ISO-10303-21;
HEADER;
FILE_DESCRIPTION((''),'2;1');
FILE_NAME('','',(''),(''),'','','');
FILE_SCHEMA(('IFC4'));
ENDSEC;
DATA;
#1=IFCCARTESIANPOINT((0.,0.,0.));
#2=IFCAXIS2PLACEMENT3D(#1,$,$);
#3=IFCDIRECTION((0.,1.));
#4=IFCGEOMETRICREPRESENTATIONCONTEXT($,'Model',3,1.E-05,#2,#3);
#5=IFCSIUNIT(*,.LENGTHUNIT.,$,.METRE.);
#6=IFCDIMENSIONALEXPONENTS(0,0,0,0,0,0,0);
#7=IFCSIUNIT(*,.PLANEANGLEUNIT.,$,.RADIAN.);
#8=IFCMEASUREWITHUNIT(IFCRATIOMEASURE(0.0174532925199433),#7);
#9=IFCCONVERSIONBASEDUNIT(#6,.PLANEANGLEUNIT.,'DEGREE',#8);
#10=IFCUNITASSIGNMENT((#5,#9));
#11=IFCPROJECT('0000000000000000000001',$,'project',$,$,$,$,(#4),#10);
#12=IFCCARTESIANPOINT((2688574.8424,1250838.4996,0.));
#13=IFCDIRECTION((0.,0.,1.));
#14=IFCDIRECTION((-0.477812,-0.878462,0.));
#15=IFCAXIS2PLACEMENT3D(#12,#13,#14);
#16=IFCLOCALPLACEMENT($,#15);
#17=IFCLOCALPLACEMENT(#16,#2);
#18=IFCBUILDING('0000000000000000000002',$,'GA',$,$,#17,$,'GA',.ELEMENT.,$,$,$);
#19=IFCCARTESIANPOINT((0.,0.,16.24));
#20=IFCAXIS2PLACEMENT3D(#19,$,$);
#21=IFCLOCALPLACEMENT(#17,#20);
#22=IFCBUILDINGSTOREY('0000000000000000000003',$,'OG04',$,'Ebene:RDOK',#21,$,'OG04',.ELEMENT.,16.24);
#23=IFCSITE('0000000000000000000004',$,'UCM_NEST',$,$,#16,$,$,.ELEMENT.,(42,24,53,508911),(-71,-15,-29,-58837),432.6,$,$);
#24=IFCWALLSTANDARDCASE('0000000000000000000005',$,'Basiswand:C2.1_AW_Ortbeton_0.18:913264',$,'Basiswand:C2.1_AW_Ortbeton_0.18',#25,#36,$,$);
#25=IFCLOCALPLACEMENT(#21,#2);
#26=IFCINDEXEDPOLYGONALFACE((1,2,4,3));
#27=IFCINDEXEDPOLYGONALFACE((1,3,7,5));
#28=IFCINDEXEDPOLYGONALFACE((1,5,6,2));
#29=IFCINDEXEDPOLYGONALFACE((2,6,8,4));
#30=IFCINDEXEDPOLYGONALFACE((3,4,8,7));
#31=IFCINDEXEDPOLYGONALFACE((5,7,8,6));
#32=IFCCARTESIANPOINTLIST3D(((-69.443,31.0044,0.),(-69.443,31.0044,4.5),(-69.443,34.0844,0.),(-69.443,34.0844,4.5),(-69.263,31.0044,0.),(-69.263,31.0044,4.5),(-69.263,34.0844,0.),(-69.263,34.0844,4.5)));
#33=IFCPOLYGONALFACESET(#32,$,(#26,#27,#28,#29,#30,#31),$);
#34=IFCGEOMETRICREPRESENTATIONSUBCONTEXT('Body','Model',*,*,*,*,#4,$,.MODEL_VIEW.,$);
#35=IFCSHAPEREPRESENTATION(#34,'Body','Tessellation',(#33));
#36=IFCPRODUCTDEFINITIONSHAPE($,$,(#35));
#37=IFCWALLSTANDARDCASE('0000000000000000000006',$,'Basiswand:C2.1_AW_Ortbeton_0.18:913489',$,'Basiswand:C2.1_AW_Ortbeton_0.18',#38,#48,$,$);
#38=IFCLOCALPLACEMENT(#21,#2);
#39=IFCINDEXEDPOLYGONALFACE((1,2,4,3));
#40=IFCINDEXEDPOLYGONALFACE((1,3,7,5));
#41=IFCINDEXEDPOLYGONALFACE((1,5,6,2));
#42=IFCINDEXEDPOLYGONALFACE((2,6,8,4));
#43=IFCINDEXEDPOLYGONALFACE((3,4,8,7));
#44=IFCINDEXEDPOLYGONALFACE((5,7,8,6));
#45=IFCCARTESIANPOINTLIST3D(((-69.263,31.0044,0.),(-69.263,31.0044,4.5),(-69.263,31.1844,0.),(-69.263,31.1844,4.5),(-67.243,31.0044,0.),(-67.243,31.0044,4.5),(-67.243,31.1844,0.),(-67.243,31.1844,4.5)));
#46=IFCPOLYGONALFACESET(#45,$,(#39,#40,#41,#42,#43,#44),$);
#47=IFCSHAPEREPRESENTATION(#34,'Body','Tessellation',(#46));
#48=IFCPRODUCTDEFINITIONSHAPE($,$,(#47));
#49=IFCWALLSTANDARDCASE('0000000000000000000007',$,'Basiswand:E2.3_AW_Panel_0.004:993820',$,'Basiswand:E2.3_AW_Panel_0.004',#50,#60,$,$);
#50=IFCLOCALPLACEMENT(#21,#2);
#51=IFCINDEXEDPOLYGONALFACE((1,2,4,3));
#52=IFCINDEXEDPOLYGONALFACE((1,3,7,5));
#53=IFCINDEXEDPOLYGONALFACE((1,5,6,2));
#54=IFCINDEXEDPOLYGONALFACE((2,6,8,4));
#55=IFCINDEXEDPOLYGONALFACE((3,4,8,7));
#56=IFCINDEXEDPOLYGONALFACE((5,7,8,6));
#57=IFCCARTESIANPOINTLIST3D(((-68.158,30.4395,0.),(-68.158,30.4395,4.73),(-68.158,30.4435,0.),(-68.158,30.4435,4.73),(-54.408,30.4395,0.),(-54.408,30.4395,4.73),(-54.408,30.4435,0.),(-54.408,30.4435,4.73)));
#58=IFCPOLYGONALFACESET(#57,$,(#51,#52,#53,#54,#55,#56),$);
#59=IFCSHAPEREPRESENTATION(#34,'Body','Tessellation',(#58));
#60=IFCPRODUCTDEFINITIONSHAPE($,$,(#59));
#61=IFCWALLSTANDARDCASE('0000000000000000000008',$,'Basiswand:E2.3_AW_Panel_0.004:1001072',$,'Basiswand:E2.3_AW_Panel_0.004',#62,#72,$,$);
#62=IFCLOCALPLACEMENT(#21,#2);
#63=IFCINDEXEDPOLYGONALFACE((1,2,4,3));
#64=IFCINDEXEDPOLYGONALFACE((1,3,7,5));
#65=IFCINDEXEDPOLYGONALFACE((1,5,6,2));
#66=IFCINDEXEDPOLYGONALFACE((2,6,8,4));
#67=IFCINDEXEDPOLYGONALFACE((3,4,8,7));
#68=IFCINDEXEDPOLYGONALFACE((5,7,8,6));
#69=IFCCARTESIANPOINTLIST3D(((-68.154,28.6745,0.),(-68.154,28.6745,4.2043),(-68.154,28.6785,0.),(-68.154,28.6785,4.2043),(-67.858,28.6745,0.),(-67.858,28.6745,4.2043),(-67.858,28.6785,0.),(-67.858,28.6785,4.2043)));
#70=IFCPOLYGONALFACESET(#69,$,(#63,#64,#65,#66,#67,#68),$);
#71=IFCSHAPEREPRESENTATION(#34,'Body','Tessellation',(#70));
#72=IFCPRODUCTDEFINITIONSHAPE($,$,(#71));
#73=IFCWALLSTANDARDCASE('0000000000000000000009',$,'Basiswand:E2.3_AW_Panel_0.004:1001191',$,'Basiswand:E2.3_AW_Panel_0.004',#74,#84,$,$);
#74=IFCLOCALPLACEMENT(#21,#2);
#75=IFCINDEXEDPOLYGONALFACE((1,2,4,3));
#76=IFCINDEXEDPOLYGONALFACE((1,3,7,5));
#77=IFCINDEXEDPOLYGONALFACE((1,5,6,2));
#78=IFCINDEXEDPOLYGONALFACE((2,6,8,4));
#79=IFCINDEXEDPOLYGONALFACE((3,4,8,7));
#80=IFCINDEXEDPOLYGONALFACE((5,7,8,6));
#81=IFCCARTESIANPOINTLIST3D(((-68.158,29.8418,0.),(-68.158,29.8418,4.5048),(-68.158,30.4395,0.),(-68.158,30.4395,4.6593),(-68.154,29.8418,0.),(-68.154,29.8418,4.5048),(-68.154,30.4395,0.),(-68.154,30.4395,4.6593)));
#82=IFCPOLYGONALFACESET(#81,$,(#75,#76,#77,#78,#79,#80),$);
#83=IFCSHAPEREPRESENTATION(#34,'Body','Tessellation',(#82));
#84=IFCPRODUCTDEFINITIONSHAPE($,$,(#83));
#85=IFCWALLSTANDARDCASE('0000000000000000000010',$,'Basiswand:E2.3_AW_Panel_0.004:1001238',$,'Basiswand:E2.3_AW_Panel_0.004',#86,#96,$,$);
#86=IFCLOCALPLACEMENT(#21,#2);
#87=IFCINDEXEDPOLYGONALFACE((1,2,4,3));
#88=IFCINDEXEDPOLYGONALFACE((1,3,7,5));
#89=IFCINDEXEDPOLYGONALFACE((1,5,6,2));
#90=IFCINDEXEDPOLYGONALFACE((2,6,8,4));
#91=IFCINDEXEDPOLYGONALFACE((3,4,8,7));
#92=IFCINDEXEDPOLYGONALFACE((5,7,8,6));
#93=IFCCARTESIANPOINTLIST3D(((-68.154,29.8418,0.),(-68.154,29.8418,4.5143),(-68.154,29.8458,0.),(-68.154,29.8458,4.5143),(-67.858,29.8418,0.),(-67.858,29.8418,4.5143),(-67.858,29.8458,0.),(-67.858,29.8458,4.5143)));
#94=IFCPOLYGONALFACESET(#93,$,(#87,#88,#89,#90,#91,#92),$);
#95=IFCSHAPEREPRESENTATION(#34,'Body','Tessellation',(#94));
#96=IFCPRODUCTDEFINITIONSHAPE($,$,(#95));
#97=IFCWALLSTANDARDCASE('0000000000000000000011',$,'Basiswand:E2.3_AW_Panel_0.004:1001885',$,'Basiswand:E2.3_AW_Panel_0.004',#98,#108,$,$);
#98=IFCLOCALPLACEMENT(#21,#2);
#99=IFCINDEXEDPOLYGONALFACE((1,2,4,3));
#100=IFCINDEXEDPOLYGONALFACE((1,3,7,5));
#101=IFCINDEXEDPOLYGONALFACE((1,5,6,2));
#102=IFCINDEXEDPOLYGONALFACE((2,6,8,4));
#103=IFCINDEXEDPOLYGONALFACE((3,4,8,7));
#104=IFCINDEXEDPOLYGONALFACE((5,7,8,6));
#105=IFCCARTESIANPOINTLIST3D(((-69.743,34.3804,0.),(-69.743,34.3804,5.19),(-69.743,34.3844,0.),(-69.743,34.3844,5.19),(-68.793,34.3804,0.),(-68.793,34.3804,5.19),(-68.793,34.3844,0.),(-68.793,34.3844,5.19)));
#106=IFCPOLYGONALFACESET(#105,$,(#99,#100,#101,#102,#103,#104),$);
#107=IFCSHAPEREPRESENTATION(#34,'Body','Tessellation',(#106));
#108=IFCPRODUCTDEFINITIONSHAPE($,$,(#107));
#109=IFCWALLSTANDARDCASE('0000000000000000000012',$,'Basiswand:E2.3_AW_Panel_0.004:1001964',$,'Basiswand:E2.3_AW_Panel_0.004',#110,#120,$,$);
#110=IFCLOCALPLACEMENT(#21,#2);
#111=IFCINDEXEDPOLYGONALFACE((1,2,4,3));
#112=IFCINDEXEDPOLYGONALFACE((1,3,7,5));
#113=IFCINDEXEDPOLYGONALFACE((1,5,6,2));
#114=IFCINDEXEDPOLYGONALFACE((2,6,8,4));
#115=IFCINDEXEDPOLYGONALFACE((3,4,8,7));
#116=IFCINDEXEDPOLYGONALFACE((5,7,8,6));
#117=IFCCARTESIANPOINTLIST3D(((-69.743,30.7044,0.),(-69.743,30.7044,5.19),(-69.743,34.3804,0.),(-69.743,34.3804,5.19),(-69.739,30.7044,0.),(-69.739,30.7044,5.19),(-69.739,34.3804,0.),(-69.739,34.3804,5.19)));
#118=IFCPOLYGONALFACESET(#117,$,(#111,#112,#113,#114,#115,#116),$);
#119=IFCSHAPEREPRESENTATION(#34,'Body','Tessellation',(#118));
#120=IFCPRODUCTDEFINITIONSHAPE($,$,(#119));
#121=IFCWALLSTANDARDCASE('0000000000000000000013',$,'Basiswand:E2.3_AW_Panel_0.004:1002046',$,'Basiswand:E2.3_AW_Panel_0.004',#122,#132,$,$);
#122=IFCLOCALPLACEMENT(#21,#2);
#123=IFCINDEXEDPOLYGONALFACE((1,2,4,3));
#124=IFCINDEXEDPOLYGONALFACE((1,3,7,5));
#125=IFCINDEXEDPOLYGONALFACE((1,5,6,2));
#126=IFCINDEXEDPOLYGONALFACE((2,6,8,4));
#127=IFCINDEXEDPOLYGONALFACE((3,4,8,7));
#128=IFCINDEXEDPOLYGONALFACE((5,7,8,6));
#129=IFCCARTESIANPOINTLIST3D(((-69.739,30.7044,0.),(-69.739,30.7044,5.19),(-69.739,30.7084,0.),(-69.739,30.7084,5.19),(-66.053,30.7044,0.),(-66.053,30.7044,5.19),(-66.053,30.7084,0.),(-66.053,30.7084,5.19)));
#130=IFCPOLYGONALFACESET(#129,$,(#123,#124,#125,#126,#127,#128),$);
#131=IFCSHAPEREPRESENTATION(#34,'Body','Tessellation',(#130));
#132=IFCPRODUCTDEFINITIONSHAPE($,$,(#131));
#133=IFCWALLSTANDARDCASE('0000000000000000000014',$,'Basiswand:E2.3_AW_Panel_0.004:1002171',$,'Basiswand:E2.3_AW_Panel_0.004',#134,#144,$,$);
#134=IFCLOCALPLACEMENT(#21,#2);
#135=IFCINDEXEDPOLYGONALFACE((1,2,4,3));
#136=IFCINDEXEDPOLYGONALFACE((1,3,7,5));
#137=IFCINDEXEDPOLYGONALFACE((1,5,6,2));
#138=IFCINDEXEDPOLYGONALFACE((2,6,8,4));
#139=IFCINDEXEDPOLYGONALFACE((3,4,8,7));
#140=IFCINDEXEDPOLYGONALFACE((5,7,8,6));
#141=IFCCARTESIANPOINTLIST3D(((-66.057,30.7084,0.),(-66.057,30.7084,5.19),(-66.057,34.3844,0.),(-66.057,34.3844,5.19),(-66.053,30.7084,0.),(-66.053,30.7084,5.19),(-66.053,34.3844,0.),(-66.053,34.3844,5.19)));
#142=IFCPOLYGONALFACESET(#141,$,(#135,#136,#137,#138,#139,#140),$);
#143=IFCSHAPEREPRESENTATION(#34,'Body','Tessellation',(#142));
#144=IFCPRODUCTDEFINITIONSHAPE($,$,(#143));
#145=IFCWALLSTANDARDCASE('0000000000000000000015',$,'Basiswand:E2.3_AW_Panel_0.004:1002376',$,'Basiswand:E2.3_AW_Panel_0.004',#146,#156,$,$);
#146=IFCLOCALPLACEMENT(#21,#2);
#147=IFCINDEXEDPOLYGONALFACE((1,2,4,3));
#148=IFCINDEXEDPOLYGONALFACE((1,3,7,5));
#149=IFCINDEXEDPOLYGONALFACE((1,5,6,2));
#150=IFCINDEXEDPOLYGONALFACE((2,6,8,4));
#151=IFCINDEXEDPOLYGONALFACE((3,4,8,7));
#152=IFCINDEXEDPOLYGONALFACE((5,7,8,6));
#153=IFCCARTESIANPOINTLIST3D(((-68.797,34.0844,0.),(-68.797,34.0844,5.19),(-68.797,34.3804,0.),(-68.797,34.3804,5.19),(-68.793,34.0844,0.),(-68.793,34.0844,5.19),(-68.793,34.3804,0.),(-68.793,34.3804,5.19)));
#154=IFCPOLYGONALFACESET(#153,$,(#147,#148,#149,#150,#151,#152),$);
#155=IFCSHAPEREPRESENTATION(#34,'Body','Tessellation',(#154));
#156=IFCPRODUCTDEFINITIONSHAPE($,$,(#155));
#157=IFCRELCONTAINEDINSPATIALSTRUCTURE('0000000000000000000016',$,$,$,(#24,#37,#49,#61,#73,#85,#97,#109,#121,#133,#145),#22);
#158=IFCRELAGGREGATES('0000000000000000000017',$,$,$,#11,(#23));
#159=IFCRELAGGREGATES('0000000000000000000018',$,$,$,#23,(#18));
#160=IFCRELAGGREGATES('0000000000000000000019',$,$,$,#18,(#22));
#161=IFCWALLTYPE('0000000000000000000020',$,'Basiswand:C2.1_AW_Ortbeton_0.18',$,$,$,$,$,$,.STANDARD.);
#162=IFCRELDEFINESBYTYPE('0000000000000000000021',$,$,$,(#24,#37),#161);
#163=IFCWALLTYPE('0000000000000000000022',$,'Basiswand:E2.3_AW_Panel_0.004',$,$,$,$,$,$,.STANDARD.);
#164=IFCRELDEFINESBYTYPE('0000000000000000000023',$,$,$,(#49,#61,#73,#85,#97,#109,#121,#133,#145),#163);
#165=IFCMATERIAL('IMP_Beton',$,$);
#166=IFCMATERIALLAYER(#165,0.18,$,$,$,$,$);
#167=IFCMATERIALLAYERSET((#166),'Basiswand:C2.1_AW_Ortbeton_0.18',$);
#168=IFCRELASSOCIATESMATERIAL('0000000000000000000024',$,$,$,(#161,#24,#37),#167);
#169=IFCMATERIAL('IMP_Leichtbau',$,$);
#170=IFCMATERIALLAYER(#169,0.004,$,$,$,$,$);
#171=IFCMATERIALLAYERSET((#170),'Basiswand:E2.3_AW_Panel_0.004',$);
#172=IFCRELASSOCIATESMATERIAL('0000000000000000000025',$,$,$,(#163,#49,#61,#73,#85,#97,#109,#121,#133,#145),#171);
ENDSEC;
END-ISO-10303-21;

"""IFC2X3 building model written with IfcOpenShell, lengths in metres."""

from ifc_helpers import new_model, entity, si_unit, converted_unit, direction, frame, frame_2d, origin, place, context, subcontext, project, spatial, rectangle, extrude, clip, halfspace, material, layer, layer_set, layer_usage, type_object, element, save


model = new_model("IFC2X3")

# Units and contexts
model_context = context("Model", 3, precision=1e-05, world=origin(), true_north=direction((0.0, 1.0)))
body_context = subcontext(model_context, "Body", "Model", "MODEL_VIEW")
ifc_project = project(units=[si_unit("LENGTHUNIT", "METRE"), converted_unit("PLANEANGLEUNIT", "DEGREE", entity("IfcRatioMeasure", 0.0174532925199433), si_unit("PLANEANGLEUNIT", "RADIAN"), dimensions=[0, 0, 0, 0, 0, 0, 0])], contexts=[model_context])

# Site, building, storey
site_placement = place(None, frame((2688574.8424, 1250838.4996, 0.0), z_axis=(0.0, 0.0, 1.0), x_axis=(-0.477812, -0.878462, 0.0)))
site = spatial("IfcSite", under=ifc_project, at=site_placement, Name="UCM_NEST", CompositionType="ELEMENT", RefLatitude=(42, 24, 53, 508911), RefLongitude=(-71, -15, -29, -58837), RefElevation=432.6)
building_placement = place(site_placement, origin())
building = spatial("IfcBuilding", under=site, at=building_placement, Name="GA", LongName="GA", CompositionType="ELEMENT")
storey_placement = place(building_placement, frame((0.0, 0.0, 16.24)))
storey = spatial("IfcBuildingStorey", under=building, at=storey_placement, Name="OG04", ObjectType="Ebene:RDOK", LongName="OG04", CompositionType="ELEMENT", Elevation=16.24)

# Shared definitions
ifc_material_1 = material(Name="IMP_Beton")

# Walls
ifc_layer_1 = layer(ifc_material_1, 0.18)
ifc_layer_set_1 = layer_set([ifc_layer_1], Name="Basiswand:C2.1_AW_Ortbeton_0.18")
ifc_layer_usage_1 = layer_usage(ifc_layer_set_1, "AXIS2", "NEGATIVE", 0.09)
wall_type_1 = type_object("IfcWallType", Name="Basiswand:C2.1_AW_Ortbeton_0.18", PredefinedType="STANDARD", material=ifc_layer_set_1)
wall_1_placement = place(storey_placement, frame((-69.353, 31.0044, 0.0), z_axis=(0.0, 0.0, 1.0), x_axis=(0.0, 1.0, 0.0)))
element("IfcWallStandardCase", 1, at=wall_1_placement, inside=storey, type_object=wall_type_1, material=ifc_layer_usage_1, Name="Basiswand:C2.1_AW_Ortbeton_0.18:913264", ObjectType="Basiswand:C2.1_AW_Ortbeton_0.18", context=body_context, shape_type="SweptSolid", body=[
    extrude(rectangle(XDim=3.08, YDim=0.18, at=frame_2d((1.54, 0.0), x_axis=(-1.0, 0.0))), origin(), (0.0, 0.0, 1.0), 4.5),
])
ifc_layer_usage_2 = layer_usage(ifc_layer_set_1, "AXIS2", "NEGATIVE", 0.09)
wall_2_placement = place(storey_placement, frame((-67.243, 31.0944, 0.0), z_axis=(0.0, 0.0, 1.0), x_axis=(-1.0, 0.0, 0.0)))
element("IfcWallStandardCase", 2, at=wall_2_placement, inside=storey, type_object=wall_type_1, material=ifc_layer_usage_2, Name="Basiswand:C2.1_AW_Ortbeton_0.18:913489", ObjectType="Basiswand:C2.1_AW_Ortbeton_0.18", context=body_context, shape_type="SweptSolid", body=[
    extrude(rectangle(XDim=2.02, YDim=0.18, at=frame_2d((1.01, 0.0), x_axis=(-1.0, 0.0))), origin(), (0.0, 0.0, 1.0), 4.5),
])
ifc_material_2 = material(Name="IMP_Leichtbau")
ifc_layer_2 = layer(ifc_material_2, 0.004)
ifc_layer_set_2 = layer_set([ifc_layer_2], Name="Basiswand:E2.3_AW_Panel_0.004")
ifc_layer_usage_3 = layer_usage(ifc_layer_set_2, "AXIS2", "NEGATIVE", 0.002)
wall_type_2 = type_object("IfcWallType", Name="Basiswand:E2.3_AW_Panel_0.004", PredefinedType="STANDARD", material=ifc_layer_set_2)
wall_3_placement = place(storey_placement, frame((-68.158, 30.4415, 0.0)))
element("IfcWallStandardCase", 3, at=wall_3_placement, inside=storey, type_object=wall_type_2, material=ifc_layer_usage_3, Name="Basiswand:E2.3_AW_Panel_0.004:993820", ObjectType="Basiswand:E2.3_AW_Panel_0.004", context=body_context, shape_type="SweptSolid", body=[
    extrude(rectangle(XDim=13.75, YDim=0.004, at=frame_2d((6.875, 0.0), x_axis=(-1.0, 0.0))), origin(), (0.0, 0.0, 1.0), 4.73),
])
ifc_layer_usage_4 = layer_usage(ifc_layer_set_2, "AXIS2", "NEGATIVE", 0.002)
wall_4_placement = place(storey_placement, frame((-68.154, 28.6765, 0.0)))
element("IfcWallStandardCase", 4, at=wall_4_placement, inside=storey, type_object=wall_type_2, material=ifc_layer_usage_4, Name="Basiswand:E2.3_AW_Panel_0.004:1001072", ObjectType="Basiswand:E2.3_AW_Panel_0.004", context=body_context, shape_type="SweptSolid", body=[
    extrude(rectangle(XDim=0.296, YDim=0.004, at=frame_2d((0.148, 0.0), x_axis=(-1.0, 0.0))), origin(), (0.0, 0.0, 1.0), 4.2043),
])
ifc_layer_usage_5 = layer_usage(ifc_layer_set_2, "AXIS2", "NEGATIVE", 0.002)
wall_5_placement = place(storey_placement, frame((-68.156, 30.4395, 0.0), z_axis=(0.0, 0.0, 1.0), x_axis=(0.0, -1.0, 0.0)))
element("IfcWallStandardCase", 5, at=wall_5_placement, inside=storey, type_object=wall_type_2, material=ifc_layer_usage_5, Name="Basiswand:E2.3_AW_Panel_0.004:1001191", ObjectType="Basiswand:E2.3_AW_Panel_0.004", context=body_context, shape_type="Clipping", body=[
    clip(extrude(rectangle(XDim=0.5977, YDim=0.004, at=frame_2d((0.2988, 0.0), x_axis=(-1.0, 0.0))), origin(), (0.0, 0.0, 1.0), 4.6593), halfspace(frame((0.0, -0.002, 4.6593), z_axis=(0.250322, 0.0, 0.968163), x_axis=(0.0, 1.0, 0.0)), False)),
])
ifc_layer_usage_6 = layer_usage(ifc_layer_set_2, "AXIS2", "NEGATIVE", 0.002)
wall_6_placement = place(storey_placement, frame((-68.154, 29.8438, 0.0)))
element("IfcWallStandardCase", 6, at=wall_6_placement, inside=storey, type_object=wall_type_2, material=ifc_layer_usage_6, Name="Basiswand:E2.3_AW_Panel_0.004:1001238", ObjectType="Basiswand:E2.3_AW_Panel_0.004", context=body_context, shape_type="SweptSolid", body=[
    extrude(rectangle(XDim=0.296, YDim=0.004, at=frame_2d((0.148, 0.0), x_axis=(-1.0, 0.0))), origin(), (0.0, 0.0, 1.0), 4.5143),
])
ifc_layer_usage_7 = layer_usage(ifc_layer_set_2, "AXIS2", "NEGATIVE", 0.002)
wall_7_placement = place(storey_placement, frame((-68.793, 34.3824, 0.0), z_axis=(0.0, 0.0, 1.0), x_axis=(-1.0, 0.0, 0.0)))
element("IfcWallStandardCase", 7, at=wall_7_placement, inside=storey, type_object=wall_type_2, material=ifc_layer_usage_7, Name="Basiswand:E2.3_AW_Panel_0.004:1001885", ObjectType="Basiswand:E2.3_AW_Panel_0.004", context=body_context, shape_type="SweptSolid", body=[
    extrude(rectangle(XDim=0.95, YDim=0.004, at=frame_2d((0.475, 0.0), x_axis=(-1.0, 0.0))), origin(), (0.0, 0.0, 1.0), 5.19),
])
ifc_layer_usage_8 = layer_usage(ifc_layer_set_2, "AXIS2", "NEGATIVE", 0.002)
wall_8_placement = place(storey_placement, frame((-69.741, 34.3804, 0.0), z_axis=(0.0, 0.0, 1.0), x_axis=(0.0, -1.0, 0.0)))
element("IfcWallStandardCase", 8, at=wall_8_placement, inside=storey, type_object=wall_type_2, material=ifc_layer_usage_8, Name="Basiswand:E2.3_AW_Panel_0.004:1001964", ObjectType="Basiswand:E2.3_AW_Panel_0.004", context=body_context, shape_type="SweptSolid", body=[
    extrude(rectangle(XDim=3.676, YDim=0.004, at=frame_2d((1.838, 0.0), x_axis=(-1.0, 0.0))), origin(), (0.0, 0.0, 1.0), 5.19),
])
ifc_layer_usage_9 = layer_usage(ifc_layer_set_2, "AXIS2", "NEGATIVE", 0.002)
wall_9_placement = place(storey_placement, frame((-69.739, 30.7064, 0.0)))
element("IfcWallStandardCase", 9, at=wall_9_placement, inside=storey, type_object=wall_type_2, material=ifc_layer_usage_9, Name="Basiswand:E2.3_AW_Panel_0.004:1002046", ObjectType="Basiswand:E2.3_AW_Panel_0.004", context=body_context, shape_type="SweptSolid", body=[
    extrude(rectangle(XDim=3.686, YDim=0.004, at=frame_2d((1.843, 0.0), x_axis=(-1.0, 0.0))), origin(), (0.0, 0.0, 1.0), 5.19),
])
ifc_layer_usage_10 = layer_usage(ifc_layer_set_2, "AXIS2", "NEGATIVE", 0.002)
wall_10_placement = place(storey_placement, frame((-66.055, 30.7084, 0.0), z_axis=(0.0, 0.0, 1.0), x_axis=(0.0, 1.0, 0.0)))
element("IfcWallStandardCase", 10, at=wall_10_placement, inside=storey, type_object=wall_type_2, material=ifc_layer_usage_10, Name="Basiswand:E2.3_AW_Panel_0.004:1002171", ObjectType="Basiswand:E2.3_AW_Panel_0.004", context=body_context, shape_type="SweptSolid", body=[
    extrude(rectangle(XDim=3.676, YDim=0.004, at=frame_2d((1.838, 0.0), x_axis=(-1.0, 0.0))), origin(), (0.0, 0.0, 1.0), 5.19),
])
ifc_layer_usage_11 = layer_usage(ifc_layer_set_2, "AXIS2", "POSITIVE", -0.002)
wall_11_placement = place(storey_placement, frame((-68.795, 34.0844, 0.0), z_axis=(0.0, 0.0, 1.0), x_axis=(0.0, 1.0, 0.0)))
element("IfcWallStandardCase", 11, at=wall_11_placement, inside=storey, type_object=wall_type_2, material=ifc_layer_usage_11, Name="Basiswand:E2.3_AW_Panel_0.004:1002376", ObjectType="Basiswand:E2.3_AW_Panel_0.004", context=body_context, shape_type="SweptSolid", body=[
    extrude(rectangle(XDim=0.296, YDim=0.004, at=frame_2d((0.148, 0.0), x_axis=(-1.0, 0.0))), origin(), (0.0, 0.0, 1.0), 5.19),
])

save(model, "model.ifc")
